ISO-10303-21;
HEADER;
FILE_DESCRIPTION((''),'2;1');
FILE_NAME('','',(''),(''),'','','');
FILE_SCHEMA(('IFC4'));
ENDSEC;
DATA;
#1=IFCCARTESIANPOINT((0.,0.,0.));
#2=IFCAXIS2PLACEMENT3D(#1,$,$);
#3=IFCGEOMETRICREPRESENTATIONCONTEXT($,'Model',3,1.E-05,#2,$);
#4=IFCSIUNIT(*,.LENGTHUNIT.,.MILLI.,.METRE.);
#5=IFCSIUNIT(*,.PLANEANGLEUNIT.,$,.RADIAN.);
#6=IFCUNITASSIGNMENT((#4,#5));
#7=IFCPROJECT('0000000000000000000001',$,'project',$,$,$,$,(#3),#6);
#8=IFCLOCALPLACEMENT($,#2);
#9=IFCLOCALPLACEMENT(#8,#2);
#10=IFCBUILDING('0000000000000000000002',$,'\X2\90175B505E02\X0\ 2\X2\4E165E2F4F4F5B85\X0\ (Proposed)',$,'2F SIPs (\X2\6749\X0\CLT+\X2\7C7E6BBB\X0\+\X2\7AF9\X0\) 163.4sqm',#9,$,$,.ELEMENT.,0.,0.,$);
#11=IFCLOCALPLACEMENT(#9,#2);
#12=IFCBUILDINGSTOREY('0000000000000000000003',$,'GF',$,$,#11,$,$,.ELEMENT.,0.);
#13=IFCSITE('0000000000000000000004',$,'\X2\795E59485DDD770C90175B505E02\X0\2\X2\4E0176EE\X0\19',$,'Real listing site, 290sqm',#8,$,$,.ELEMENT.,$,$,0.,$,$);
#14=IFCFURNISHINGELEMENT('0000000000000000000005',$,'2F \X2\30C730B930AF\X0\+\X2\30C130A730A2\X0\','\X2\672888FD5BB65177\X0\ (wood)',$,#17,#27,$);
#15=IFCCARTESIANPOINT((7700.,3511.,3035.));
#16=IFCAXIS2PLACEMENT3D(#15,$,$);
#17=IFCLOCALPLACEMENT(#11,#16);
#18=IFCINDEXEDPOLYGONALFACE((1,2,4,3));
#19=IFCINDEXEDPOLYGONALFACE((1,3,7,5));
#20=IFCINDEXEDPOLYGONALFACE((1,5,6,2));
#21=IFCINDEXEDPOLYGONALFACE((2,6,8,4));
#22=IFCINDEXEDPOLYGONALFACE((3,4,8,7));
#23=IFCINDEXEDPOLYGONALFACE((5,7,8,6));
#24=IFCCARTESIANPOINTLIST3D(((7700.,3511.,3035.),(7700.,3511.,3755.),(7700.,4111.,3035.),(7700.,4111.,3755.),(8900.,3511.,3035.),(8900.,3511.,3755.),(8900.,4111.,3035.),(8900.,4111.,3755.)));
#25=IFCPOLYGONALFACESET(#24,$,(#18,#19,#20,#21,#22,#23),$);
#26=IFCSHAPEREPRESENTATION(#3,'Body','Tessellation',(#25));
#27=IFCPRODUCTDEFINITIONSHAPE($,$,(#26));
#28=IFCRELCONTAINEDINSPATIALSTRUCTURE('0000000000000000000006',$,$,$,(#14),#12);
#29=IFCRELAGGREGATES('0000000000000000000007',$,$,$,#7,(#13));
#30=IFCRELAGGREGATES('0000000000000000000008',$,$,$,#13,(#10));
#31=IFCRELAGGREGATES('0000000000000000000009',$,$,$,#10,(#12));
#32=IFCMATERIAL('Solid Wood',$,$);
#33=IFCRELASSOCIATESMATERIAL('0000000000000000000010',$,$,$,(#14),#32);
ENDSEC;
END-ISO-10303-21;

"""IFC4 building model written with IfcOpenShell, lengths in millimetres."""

from ifc_helpers import new_model, si_unit, frame, frame_2d, origin, place, context, project, spatial, rectangle, extrude, material, element, save


model = new_model("IFC4")

# Units and contexts
model_context = context("Model", 3, precision=1e-05, world=origin())
ifc_project = project(units=[si_unit("LENGTHUNIT", "METRE", prefix="MILLI"), si_unit("PLANEANGLEUNIT", "RADIAN")], contexts=[model_context])

# Site, building, storey
site_placement = place(None, origin())
site = spatial("IfcSite", under=ifc_project, at=site_placement, Name="神奈川県逗子市2丁目19", ObjectType="Real listing site, 290sqm", CompositionType="ELEMENT", RefElevation=0.0)
building_placement = place(site_placement, origin())
building = spatial("IfcBuilding", under=site, at=building_placement, Name="逗子市 2世帯住宅 (Proposed)", ObjectType="2F SIPs (杉CLT+籾殻+竹) 163.4sqm", CompositionType="ELEMENT", ElevationOfRefHeight=0.0, ElevationOfTerrain=0.0)
storey_placement = place(building_placement, origin())
storey = spatial("IfcBuildingStorey", under=building, at=storey_placement, Name="GF", CompositionType="ELEMENT", Elevation=0.0)

# Shared definitions
ifc_material_1 = material(Name="Solid Wood")

# Furnishing element
furnishing_1_placement = place(storey_placement, frame((7700.0, 3511.0, 3035.0)))
element("IfcFurnishingElement", 1, at=furnishing_1_placement, inside=storey, material=ifc_material_1, Name="2F デスク+チェア", Description="木製家具 (wood)", context=model_context, shape_type="SweptSolid", body=[
    extrude(rectangle(XDim=1200.0, YDim=600.0, at=frame_2d((600.0, 300.0))), frame((7700.0, 3511.0, 3035.0)), (0.0, 0.0, 1.0), 720.0),
])

save(model, "model.ifc")
